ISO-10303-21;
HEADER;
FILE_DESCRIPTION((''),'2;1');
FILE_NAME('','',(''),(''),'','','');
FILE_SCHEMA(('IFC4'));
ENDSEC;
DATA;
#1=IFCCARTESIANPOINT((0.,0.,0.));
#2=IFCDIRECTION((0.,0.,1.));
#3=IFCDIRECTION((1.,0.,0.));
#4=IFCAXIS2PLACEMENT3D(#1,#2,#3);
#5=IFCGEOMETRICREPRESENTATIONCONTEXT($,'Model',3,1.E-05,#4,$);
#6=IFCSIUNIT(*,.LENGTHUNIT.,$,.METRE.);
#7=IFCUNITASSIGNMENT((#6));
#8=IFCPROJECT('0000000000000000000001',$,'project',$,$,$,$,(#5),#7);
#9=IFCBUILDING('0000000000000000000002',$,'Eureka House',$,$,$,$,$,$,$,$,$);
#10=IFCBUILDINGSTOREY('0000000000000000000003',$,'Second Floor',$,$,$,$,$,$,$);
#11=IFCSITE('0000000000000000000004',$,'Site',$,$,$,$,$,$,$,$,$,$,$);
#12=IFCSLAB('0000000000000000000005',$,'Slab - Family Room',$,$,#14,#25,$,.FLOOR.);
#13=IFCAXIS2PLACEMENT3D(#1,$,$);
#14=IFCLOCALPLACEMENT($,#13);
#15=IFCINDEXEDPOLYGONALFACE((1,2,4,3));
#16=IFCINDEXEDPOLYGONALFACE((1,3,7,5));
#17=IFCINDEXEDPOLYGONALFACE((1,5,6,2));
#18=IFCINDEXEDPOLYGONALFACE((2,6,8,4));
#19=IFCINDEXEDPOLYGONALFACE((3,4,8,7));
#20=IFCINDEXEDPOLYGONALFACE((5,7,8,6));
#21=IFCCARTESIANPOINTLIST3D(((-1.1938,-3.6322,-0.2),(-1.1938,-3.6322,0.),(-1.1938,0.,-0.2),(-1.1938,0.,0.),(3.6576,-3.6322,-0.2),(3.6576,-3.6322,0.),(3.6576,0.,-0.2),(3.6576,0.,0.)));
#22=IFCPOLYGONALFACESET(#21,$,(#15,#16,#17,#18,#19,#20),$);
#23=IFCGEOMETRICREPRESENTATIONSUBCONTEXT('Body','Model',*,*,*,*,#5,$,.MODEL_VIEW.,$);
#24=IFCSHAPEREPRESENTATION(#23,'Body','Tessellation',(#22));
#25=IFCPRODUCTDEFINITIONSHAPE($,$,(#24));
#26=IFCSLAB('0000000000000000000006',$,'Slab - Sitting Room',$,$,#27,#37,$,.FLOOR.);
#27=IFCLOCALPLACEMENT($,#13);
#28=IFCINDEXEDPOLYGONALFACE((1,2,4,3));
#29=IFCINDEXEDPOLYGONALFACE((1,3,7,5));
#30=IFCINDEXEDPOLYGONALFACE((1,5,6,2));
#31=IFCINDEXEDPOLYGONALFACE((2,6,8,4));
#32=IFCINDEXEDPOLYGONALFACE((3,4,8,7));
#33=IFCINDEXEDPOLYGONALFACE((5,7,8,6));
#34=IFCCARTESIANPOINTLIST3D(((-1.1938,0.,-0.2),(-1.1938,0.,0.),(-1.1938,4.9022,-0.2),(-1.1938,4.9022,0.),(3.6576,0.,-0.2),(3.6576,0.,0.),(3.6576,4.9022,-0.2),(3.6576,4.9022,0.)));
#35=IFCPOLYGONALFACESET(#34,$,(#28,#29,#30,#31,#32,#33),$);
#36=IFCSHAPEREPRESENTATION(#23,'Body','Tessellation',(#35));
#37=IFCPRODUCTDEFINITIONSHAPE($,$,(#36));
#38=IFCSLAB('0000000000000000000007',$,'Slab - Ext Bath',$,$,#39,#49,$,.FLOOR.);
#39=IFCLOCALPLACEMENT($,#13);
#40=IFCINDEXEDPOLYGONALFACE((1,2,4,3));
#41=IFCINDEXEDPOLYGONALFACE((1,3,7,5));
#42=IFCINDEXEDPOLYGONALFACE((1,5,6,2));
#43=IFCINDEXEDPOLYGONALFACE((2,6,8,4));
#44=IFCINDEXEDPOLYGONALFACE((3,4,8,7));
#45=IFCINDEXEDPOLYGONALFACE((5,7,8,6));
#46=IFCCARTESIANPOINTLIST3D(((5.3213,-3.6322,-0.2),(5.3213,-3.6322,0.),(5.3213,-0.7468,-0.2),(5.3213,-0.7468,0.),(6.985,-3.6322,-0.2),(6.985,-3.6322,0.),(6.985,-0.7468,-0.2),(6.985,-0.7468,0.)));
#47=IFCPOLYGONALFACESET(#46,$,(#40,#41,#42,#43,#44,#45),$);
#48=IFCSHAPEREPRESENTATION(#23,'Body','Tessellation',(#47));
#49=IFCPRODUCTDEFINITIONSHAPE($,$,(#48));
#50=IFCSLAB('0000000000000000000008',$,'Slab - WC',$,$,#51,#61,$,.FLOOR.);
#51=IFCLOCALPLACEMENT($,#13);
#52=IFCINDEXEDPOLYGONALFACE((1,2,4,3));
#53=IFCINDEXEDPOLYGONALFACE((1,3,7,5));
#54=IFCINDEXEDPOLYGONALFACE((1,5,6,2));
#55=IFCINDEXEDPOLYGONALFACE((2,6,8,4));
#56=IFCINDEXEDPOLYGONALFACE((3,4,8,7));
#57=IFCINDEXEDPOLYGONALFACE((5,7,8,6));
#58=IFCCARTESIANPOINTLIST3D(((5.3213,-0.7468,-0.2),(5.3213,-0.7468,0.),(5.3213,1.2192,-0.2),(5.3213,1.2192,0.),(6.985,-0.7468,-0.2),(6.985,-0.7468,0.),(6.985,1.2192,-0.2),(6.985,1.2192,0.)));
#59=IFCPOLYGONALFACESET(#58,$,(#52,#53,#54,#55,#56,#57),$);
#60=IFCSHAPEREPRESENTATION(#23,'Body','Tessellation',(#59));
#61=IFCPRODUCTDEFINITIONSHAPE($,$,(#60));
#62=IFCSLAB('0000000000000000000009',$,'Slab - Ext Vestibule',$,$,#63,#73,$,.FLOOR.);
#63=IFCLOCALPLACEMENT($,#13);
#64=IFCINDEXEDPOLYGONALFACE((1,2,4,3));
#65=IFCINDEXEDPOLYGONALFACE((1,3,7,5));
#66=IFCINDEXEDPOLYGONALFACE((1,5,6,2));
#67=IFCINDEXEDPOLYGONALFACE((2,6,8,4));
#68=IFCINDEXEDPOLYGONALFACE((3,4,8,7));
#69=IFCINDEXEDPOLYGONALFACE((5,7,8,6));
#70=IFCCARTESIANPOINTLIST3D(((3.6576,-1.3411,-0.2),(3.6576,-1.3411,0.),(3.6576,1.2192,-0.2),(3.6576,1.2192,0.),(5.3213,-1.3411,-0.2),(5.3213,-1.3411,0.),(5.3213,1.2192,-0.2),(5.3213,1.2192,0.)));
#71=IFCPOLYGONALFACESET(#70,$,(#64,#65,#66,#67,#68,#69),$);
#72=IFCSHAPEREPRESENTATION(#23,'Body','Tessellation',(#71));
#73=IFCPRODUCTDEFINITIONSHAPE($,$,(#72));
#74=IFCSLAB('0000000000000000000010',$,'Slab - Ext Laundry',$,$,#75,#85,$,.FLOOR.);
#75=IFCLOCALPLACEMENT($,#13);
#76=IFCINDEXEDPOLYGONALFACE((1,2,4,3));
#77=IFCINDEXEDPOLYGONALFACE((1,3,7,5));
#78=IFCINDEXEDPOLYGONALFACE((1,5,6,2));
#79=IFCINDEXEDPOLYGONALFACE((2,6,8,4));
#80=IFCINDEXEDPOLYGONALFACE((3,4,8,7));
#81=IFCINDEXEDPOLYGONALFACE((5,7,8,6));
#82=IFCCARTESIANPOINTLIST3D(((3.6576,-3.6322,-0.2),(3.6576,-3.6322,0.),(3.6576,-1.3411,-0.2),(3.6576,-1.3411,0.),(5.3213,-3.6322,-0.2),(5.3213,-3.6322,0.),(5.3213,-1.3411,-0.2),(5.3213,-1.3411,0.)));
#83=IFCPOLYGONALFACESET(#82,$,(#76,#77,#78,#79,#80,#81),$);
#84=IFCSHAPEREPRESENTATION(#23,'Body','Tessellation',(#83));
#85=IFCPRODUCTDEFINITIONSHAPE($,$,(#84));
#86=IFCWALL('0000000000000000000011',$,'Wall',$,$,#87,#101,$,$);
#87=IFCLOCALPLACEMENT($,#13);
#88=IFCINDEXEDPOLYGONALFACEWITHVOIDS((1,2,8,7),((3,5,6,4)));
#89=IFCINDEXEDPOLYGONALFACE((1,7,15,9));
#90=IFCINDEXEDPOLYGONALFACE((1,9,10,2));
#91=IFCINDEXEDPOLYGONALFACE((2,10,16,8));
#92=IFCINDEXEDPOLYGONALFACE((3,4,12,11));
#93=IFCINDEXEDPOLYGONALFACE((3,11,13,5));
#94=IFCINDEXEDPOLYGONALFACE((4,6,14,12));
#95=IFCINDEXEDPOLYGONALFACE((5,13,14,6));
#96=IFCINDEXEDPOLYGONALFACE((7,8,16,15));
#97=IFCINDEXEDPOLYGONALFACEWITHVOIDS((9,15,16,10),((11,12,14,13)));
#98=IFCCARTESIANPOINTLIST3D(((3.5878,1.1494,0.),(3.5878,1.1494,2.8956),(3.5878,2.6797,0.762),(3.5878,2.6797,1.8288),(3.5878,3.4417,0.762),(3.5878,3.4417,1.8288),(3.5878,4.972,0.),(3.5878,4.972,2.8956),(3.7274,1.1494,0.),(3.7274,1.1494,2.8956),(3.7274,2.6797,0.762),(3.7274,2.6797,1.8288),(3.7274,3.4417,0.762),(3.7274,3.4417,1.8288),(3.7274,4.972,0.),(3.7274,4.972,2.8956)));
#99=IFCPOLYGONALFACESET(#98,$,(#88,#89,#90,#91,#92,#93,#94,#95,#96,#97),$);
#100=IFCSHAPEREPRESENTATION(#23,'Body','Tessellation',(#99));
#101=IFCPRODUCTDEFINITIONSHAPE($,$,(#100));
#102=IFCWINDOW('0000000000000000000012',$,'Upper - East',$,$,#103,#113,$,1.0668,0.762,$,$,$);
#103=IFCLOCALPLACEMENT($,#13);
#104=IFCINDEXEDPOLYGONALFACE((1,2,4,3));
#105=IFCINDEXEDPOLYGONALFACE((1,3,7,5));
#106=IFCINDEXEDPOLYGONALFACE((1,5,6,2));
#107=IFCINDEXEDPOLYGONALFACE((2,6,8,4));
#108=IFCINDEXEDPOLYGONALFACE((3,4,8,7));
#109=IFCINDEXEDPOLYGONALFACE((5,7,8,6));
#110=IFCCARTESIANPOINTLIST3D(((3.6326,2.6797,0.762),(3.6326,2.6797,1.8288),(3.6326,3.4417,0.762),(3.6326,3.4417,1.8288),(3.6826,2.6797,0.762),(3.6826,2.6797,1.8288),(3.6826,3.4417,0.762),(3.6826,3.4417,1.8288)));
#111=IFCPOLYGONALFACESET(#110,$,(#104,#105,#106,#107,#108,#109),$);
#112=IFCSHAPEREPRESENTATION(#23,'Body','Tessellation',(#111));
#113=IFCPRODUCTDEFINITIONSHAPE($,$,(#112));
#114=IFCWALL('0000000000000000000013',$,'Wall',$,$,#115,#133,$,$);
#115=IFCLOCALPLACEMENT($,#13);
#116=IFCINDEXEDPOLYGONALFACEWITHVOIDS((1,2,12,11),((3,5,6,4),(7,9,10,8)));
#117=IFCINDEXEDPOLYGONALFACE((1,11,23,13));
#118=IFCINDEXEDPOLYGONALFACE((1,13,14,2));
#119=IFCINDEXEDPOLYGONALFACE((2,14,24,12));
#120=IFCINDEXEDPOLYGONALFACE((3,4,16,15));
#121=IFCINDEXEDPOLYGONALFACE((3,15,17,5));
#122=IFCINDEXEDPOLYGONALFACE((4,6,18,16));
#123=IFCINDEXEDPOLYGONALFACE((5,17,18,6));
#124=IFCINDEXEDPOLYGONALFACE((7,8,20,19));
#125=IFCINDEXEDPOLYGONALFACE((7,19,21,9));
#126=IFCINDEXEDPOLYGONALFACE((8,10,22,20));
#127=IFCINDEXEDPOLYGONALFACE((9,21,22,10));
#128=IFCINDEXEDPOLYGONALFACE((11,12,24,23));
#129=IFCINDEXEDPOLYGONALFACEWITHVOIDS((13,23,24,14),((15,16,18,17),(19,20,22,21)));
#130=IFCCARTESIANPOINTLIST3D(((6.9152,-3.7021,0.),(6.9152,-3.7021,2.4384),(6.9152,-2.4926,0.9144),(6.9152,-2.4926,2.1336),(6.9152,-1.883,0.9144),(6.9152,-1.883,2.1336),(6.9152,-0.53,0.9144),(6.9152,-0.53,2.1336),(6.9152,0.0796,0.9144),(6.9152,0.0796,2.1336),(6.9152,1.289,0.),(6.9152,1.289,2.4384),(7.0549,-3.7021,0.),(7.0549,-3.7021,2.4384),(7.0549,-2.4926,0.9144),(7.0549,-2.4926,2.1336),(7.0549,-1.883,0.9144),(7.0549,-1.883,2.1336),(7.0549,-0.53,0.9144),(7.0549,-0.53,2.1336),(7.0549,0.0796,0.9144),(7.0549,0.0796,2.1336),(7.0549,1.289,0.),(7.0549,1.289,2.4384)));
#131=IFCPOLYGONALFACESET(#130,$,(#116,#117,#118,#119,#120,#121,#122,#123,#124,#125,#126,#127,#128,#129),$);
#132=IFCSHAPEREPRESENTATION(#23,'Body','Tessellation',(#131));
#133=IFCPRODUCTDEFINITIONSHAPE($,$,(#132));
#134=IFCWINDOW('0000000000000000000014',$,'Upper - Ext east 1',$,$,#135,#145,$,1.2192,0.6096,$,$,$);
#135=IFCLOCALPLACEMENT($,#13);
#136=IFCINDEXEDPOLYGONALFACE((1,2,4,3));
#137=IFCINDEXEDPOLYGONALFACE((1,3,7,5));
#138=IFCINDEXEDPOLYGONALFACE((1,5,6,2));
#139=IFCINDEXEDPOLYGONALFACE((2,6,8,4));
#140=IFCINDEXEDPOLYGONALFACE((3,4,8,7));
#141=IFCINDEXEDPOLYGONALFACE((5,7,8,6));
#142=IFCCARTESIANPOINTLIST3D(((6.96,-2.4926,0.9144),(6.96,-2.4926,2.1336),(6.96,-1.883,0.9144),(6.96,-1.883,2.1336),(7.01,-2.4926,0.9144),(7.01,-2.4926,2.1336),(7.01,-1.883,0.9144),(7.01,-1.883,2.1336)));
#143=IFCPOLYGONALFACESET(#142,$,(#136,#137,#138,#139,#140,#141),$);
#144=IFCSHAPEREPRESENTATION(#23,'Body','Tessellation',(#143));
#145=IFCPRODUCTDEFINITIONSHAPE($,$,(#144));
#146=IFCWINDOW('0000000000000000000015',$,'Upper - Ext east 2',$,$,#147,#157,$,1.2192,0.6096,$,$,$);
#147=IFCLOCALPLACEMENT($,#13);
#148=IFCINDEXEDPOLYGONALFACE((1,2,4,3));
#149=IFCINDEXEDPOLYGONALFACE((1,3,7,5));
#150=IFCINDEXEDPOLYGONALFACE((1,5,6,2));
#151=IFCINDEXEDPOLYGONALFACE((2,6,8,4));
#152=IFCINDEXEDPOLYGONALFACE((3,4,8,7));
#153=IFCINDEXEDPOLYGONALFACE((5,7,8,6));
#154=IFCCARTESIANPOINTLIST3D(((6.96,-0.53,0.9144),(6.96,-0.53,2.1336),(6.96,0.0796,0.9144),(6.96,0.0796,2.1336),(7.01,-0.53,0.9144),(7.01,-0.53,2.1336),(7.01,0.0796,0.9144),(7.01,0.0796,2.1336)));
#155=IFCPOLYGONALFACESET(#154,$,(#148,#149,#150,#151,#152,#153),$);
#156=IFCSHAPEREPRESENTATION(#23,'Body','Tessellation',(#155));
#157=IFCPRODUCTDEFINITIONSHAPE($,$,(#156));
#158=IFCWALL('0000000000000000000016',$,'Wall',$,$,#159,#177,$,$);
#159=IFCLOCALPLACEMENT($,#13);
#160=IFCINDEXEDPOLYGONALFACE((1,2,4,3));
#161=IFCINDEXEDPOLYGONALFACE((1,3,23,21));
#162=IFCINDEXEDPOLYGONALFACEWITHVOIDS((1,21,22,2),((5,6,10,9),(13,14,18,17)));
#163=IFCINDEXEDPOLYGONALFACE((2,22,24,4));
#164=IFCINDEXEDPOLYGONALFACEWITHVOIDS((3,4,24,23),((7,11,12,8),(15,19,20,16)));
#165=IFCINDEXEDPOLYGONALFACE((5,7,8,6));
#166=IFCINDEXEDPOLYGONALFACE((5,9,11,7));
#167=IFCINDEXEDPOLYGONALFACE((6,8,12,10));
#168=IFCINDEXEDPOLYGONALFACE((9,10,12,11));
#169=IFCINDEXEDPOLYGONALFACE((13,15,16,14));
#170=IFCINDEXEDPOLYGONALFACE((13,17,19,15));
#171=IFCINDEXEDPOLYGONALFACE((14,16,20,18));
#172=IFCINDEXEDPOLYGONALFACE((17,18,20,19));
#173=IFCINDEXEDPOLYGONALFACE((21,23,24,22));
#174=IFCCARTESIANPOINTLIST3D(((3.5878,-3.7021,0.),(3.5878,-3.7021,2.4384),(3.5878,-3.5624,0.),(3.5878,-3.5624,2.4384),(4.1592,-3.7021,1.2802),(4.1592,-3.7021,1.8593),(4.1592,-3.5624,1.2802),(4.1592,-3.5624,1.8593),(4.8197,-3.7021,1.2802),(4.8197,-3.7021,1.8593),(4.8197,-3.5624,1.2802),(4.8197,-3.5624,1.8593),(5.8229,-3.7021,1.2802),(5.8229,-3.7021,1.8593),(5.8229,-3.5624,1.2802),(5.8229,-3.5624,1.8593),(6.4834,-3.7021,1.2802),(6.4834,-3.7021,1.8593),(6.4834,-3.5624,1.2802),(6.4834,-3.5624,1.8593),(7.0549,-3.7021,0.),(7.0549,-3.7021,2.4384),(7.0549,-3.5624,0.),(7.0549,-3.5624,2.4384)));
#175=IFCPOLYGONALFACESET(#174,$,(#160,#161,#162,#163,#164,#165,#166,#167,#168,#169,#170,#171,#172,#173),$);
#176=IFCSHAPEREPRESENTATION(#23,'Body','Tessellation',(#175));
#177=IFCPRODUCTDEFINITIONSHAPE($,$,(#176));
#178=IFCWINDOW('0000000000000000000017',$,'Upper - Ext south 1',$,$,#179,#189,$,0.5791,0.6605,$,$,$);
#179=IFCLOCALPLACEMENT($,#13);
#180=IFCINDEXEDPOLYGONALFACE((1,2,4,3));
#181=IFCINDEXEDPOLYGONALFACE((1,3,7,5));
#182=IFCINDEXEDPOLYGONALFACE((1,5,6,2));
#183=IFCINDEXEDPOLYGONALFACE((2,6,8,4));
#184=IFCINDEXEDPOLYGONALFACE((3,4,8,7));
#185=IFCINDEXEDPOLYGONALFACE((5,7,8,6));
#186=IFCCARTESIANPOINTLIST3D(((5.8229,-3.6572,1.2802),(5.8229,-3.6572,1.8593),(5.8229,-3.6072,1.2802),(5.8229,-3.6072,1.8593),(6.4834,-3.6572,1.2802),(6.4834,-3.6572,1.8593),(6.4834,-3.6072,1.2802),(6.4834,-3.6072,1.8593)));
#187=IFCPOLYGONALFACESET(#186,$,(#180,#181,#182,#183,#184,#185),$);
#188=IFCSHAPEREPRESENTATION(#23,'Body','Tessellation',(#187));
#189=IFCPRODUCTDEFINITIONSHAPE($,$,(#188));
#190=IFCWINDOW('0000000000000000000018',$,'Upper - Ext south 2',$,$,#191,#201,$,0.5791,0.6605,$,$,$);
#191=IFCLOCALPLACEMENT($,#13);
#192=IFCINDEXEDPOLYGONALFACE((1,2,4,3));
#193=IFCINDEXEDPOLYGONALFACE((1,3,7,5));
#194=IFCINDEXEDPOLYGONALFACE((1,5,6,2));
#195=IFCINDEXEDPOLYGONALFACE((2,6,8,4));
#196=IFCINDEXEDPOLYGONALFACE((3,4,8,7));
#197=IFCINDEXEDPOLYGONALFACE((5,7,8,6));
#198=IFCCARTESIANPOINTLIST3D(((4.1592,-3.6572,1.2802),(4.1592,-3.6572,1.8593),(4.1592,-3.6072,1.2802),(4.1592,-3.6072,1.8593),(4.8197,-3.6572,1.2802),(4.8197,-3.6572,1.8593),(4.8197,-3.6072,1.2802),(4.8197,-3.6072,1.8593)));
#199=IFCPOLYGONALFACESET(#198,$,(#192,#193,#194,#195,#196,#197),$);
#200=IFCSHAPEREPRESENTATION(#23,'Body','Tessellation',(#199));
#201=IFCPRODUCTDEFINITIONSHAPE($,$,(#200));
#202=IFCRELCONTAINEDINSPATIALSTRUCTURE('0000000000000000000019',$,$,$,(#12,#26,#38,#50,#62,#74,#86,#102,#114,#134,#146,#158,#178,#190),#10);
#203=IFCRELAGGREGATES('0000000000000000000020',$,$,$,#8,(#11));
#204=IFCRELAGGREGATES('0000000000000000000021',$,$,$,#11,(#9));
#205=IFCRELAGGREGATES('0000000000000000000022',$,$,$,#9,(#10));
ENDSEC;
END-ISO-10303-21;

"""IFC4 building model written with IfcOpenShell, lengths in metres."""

from ifc_helpers import new_model, si_unit, frame, origin, origin_with_axes, origin_2d, place, context, subcontext, project, spatial, rectangle, extrude, element, fill, save


model = new_model("IFC4")

# Units and contexts
model_context = context("Model", 3, precision=1e-05, world=origin_with_axes())
body_context = subcontext(model_context, "Body", "Model", "MODEL_VIEW")
ifc_project = project(units=[si_unit("LENGTHUNIT", "METRE")], contexts=[model_context])

# Site, building, storey
site = spatial("IfcSite", under=ifc_project, Name="Site")
building = spatial("IfcBuilding", under=site, Name="Eureka House")
storey = spatial("IfcBuildingStorey", under=building, Name="Second Floor")

# Slabs
slab_1_placement = place(None, frame((1.2319, -1.8161, -0.2), z_axis=(0.0, 0.0, 1.0), x_axis=(1.0, 0.0, 0.0)))
element("IfcSlab", 1, at=slab_1_placement, inside=storey, Name="Slab - Family Room", PredefinedType="FLOOR", context=body_context, shape_type="SweptSolid", body=[
    extrude(rectangle(XDim=4.8514, YDim=3.6322, at=origin_2d()), origin(), (0.0, 0.0, 1.0), 0.2),
])
slab_2_placement = place(None, frame((1.2319, 2.4511, -0.2), z_axis=(0.0, 0.0, 1.0), x_axis=(1.0, 0.0, 0.0)))
element("IfcSlab", 2, at=slab_2_placement, inside=storey, Name="Slab - Sitting Room", PredefinedType="FLOOR", context=body_context, shape_type="SweptSolid", body=[
    extrude(rectangle(XDim=4.8514, YDim=4.9022, at=origin_2d()), origin(), (0.0, 0.0, 1.0), 0.2),
])
slab_3_placement = place(None, frame((6.1532, -2.1895, -0.2), z_axis=(0.0, 0.0, 1.0), x_axis=(1.0, 0.0, 0.0)))
element("IfcSlab", 3, at=slab_3_placement, inside=storey, Name="Slab - Ext Bath", PredefinedType="FLOOR", context=body_context, shape_type="SweptSolid", body=[
    extrude(rectangle(XDim=1.6637, YDim=2.8855, at=origin_2d()), origin(), (0.0, 0.0, 1.0), 0.2),
])
slab_4_placement = place(None, frame((6.1532, 0.2362, -0.2), z_axis=(0.0, 0.0, 1.0), x_axis=(1.0, 0.0, 0.0)))
element("IfcSlab", 4, at=slab_4_placement, inside=storey, Name="Slab - WC", PredefinedType="FLOOR", context=body_context, shape_type="SweptSolid", body=[
    extrude(rectangle(XDim=1.6637, YDim=1.966, at=origin_2d()), origin(), (0.0, 0.0, 1.0), 0.2),
])
slab_5_placement = place(None, frame((4.4894, -0.061, -0.2), z_axis=(0.0, 0.0, 1.0), x_axis=(1.0, 0.0, 0.0)))
element("IfcSlab", 5, at=slab_5_placement, inside=storey, Name="Slab - Ext Vestibule", PredefinedType="FLOOR", context=body_context, shape_type="SweptSolid", body=[
    extrude(rectangle(XDim=1.6637, YDim=2.5603, at=origin_2d()), origin(), (0.0, 0.0, 1.0), 0.2),
])
slab_6_placement = place(None, frame((4.4894, -2.4867, -0.2), z_axis=(0.0, 0.0, 1.0), x_axis=(1.0, 0.0, 0.0)))
element("IfcSlab", 6, at=slab_6_placement, inside=storey, Name="Slab - Ext Laundry", PredefinedType="FLOOR", context=body_context, shape_type="SweptSolid", body=[
    extrude(rectangle(XDim=1.6637, YDim=2.2911, at=origin_2d()), origin(), (0.0, 0.0, 1.0), 0.2),
])

# Wall, opening, window
wall_1_placement = place(None, frame((3.6576, 3.0607, 0.0), z_axis=(0.0, 0.0, 1.0), x_axis=(1.0, 0.0, 0.0)))
wall_1 = element("IfcWall", 7, at=wall_1_placement, inside=storey, Name="Wall", context=body_context, shape_type="SweptSolid", body=[
    extrude(rectangle(XDim=0.1397, YDim=3.8227, at=origin_2d()), origin(), (0.0, 0.0, 1.0), 2.8956),
])
opening_1_placement = place(wall_1_placement, frame((0.0, 0.0, 0.762), z_axis=(0.0, 0.0, 1.0), x_axis=(1.0, 0.0, 0.0)))
opening_1 = element("IfcOpeningElement", 8, at=opening_1_placement, cuts=wall_1, context=body_context, shape_type="SweptSolid", body=[
    extrude(rectangle(XDim=0.2397, YDim=0.762, at=origin_2d()), origin(), (0.0, 0.0, 1.0), 1.0668),
])
window_1_placement = place(opening_1_placement, origin_with_axes())
window_1 = element("IfcWindow", 9, at=window_1_placement, inside=storey, Name="Upper - East", OverallHeight=1.0668, OverallWidth=0.762, context=body_context, shape_type="SweptSolid", body=[
    extrude(rectangle(XDim=0.05, YDim=0.762, at=origin_2d()), origin(), (0.0, 0.0, 1.0), 1.0668),
])
fill(opening_1, window_1)

# Walls, openings, windows
wall_2_placement = place(None, frame((6.985, -1.2065, 0.0), z_axis=(0.0, 0.0, 1.0), x_axis=(1.0, 0.0, 0.0)))
wall_2 = element("IfcWall", 10, at=wall_2_placement, inside=storey, Name="Wall", context=body_context, shape_type="SweptSolid", body=[
    extrude(rectangle(XDim=0.1397, YDim=4.9911, at=origin_2d()), origin(), (0.0, 0.0, 1.0), 2.4384),
])
opening_2_placement = place(wall_2_placement, frame((0.0, -0.9813, 0.9144), z_axis=(0.0, 0.0, 1.0), x_axis=(1.0, 0.0, 0.0)))
opening_2 = element("IfcOpeningElement", 11, at=opening_2_placement, cuts=wall_2, context=body_context, shape_type="SweptSolid", body=[
    extrude(rectangle(XDim=0.2397, YDim=0.6096, at=origin_2d()), origin(), (0.0, 0.0, 1.0), 1.2192),
])
opening_3_placement = place(wall_2_placement, frame((0.0, 0.9813, 0.9144), z_axis=(0.0, 0.0, 1.0), x_axis=(1.0, 0.0, 0.0)))
opening_3 = element("IfcOpeningElement", 12, at=opening_3_placement, cuts=wall_2, context=body_context, shape_type="SweptSolid", body=[
    extrude(rectangle(XDim=0.2397, YDim=0.6096, at=origin_2d()), origin(), (0.0, 0.0, 1.0), 1.2192),
])
window_2_placement = place(opening_2_placement, origin_with_axes())
window_2 = element("IfcWindow", 13, at=window_2_placement, inside=storey, Name="Upper - Ext east 1", OverallHeight=1.2192, OverallWidth=0.6096, context=body_context, shape_type="SweptSolid", body=[
    extrude(rectangle(XDim=0.05, YDim=0.6096, at=origin_2d()), origin(), (0.0, 0.0, 1.0), 1.2192),
])
fill(opening_2, window_2)
window_3_placement = place(opening_3_placement, origin_with_axes())
window_3 = element("IfcWindow", 14, at=window_3_placement, inside=storey, Name="Upper - Ext east 2", OverallHeight=1.2192, OverallWidth=0.6096, context=body_context, shape_type="SweptSolid", body=[
    extrude(rectangle(XDim=0.05, YDim=0.6096, at=origin_2d()), origin(), (0.0, 0.0, 1.0), 1.2192),
])
fill(opening_3, window_3)
wall_3_placement = place(None, frame((5.3213, -3.6322, 0.0), z_axis=(0.0, 0.0, 1.0), x_axis=(1.0, 0.0, 0.0)))
wall_3 = element("IfcWall", 15, at=wall_3_placement, inside=storey, Name="Wall", context=body_context, shape_type="SweptSolid", body=[
    extrude(rectangle(XDim=3.4671, YDim=0.1397, at=origin_2d()), origin(), (0.0, 0.0, 1.0), 2.4384),
])
opening_4_placement = place(wall_3_placement, frame((0.8318, 0.0, 1.2802), z_axis=(0.0, 0.0, 1.0), x_axis=(1.0, 0.0, 0.0)))
opening_4 = element("IfcOpeningElement", 16, at=opening_4_placement, cuts=wall_3, context=body_context, shape_type="SweptSolid", body=[
    extrude(rectangle(XDim=0.6605, YDim=0.2397, at=origin_2d()), origin(), (0.0, 0.0, 1.0), 0.5791),
])
opening_5_placement = place(wall_3_placement, frame((-0.8319, 0.0, 1.2802), z_axis=(0.0, 0.0, 1.0), x_axis=(1.0, 0.0, 0.0)))
opening_5 = element("IfcOpeningElement", 17, at=opening_5_placement, cuts=wall_3, context=body_context, shape_type="SweptSolid", body=[
    extrude(rectangle(XDim=0.6605, YDim=0.2397, at=origin_2d()), origin(), (0.0, 0.0, 1.0), 0.5791),
])
window_4_placement = place(opening_4_placement, origin_with_axes())
window_4 = element("IfcWindow", 18, at=window_4_placement, inside=storey, Name="Upper - Ext south 1", OverallHeight=0.5791, OverallWidth=0.6605, context=body_context, shape_type="SweptSolid", body=[
    extrude(rectangle(XDim=0.6605, YDim=0.05, at=origin_2d()), origin(), (0.0, 0.0, 1.0), 0.5791),
])
fill(opening_4, window_4)
window_5_placement = place(opening_5_placement, origin_with_axes())
window_5 = element("IfcWindow", 19, at=window_5_placement, inside=storey, Name="Upper - Ext south 2", OverallHeight=0.5791, OverallWidth=0.6605, context=body_context, shape_type="SweptSolid", body=[
    extrude(rectangle(XDim=0.6605, YDim=0.05, at=origin_2d()), origin(), (0.0, 0.0, 1.0), 0.5791),
])
fill(opening_5, window_5)

save(model, "model.ifc")
